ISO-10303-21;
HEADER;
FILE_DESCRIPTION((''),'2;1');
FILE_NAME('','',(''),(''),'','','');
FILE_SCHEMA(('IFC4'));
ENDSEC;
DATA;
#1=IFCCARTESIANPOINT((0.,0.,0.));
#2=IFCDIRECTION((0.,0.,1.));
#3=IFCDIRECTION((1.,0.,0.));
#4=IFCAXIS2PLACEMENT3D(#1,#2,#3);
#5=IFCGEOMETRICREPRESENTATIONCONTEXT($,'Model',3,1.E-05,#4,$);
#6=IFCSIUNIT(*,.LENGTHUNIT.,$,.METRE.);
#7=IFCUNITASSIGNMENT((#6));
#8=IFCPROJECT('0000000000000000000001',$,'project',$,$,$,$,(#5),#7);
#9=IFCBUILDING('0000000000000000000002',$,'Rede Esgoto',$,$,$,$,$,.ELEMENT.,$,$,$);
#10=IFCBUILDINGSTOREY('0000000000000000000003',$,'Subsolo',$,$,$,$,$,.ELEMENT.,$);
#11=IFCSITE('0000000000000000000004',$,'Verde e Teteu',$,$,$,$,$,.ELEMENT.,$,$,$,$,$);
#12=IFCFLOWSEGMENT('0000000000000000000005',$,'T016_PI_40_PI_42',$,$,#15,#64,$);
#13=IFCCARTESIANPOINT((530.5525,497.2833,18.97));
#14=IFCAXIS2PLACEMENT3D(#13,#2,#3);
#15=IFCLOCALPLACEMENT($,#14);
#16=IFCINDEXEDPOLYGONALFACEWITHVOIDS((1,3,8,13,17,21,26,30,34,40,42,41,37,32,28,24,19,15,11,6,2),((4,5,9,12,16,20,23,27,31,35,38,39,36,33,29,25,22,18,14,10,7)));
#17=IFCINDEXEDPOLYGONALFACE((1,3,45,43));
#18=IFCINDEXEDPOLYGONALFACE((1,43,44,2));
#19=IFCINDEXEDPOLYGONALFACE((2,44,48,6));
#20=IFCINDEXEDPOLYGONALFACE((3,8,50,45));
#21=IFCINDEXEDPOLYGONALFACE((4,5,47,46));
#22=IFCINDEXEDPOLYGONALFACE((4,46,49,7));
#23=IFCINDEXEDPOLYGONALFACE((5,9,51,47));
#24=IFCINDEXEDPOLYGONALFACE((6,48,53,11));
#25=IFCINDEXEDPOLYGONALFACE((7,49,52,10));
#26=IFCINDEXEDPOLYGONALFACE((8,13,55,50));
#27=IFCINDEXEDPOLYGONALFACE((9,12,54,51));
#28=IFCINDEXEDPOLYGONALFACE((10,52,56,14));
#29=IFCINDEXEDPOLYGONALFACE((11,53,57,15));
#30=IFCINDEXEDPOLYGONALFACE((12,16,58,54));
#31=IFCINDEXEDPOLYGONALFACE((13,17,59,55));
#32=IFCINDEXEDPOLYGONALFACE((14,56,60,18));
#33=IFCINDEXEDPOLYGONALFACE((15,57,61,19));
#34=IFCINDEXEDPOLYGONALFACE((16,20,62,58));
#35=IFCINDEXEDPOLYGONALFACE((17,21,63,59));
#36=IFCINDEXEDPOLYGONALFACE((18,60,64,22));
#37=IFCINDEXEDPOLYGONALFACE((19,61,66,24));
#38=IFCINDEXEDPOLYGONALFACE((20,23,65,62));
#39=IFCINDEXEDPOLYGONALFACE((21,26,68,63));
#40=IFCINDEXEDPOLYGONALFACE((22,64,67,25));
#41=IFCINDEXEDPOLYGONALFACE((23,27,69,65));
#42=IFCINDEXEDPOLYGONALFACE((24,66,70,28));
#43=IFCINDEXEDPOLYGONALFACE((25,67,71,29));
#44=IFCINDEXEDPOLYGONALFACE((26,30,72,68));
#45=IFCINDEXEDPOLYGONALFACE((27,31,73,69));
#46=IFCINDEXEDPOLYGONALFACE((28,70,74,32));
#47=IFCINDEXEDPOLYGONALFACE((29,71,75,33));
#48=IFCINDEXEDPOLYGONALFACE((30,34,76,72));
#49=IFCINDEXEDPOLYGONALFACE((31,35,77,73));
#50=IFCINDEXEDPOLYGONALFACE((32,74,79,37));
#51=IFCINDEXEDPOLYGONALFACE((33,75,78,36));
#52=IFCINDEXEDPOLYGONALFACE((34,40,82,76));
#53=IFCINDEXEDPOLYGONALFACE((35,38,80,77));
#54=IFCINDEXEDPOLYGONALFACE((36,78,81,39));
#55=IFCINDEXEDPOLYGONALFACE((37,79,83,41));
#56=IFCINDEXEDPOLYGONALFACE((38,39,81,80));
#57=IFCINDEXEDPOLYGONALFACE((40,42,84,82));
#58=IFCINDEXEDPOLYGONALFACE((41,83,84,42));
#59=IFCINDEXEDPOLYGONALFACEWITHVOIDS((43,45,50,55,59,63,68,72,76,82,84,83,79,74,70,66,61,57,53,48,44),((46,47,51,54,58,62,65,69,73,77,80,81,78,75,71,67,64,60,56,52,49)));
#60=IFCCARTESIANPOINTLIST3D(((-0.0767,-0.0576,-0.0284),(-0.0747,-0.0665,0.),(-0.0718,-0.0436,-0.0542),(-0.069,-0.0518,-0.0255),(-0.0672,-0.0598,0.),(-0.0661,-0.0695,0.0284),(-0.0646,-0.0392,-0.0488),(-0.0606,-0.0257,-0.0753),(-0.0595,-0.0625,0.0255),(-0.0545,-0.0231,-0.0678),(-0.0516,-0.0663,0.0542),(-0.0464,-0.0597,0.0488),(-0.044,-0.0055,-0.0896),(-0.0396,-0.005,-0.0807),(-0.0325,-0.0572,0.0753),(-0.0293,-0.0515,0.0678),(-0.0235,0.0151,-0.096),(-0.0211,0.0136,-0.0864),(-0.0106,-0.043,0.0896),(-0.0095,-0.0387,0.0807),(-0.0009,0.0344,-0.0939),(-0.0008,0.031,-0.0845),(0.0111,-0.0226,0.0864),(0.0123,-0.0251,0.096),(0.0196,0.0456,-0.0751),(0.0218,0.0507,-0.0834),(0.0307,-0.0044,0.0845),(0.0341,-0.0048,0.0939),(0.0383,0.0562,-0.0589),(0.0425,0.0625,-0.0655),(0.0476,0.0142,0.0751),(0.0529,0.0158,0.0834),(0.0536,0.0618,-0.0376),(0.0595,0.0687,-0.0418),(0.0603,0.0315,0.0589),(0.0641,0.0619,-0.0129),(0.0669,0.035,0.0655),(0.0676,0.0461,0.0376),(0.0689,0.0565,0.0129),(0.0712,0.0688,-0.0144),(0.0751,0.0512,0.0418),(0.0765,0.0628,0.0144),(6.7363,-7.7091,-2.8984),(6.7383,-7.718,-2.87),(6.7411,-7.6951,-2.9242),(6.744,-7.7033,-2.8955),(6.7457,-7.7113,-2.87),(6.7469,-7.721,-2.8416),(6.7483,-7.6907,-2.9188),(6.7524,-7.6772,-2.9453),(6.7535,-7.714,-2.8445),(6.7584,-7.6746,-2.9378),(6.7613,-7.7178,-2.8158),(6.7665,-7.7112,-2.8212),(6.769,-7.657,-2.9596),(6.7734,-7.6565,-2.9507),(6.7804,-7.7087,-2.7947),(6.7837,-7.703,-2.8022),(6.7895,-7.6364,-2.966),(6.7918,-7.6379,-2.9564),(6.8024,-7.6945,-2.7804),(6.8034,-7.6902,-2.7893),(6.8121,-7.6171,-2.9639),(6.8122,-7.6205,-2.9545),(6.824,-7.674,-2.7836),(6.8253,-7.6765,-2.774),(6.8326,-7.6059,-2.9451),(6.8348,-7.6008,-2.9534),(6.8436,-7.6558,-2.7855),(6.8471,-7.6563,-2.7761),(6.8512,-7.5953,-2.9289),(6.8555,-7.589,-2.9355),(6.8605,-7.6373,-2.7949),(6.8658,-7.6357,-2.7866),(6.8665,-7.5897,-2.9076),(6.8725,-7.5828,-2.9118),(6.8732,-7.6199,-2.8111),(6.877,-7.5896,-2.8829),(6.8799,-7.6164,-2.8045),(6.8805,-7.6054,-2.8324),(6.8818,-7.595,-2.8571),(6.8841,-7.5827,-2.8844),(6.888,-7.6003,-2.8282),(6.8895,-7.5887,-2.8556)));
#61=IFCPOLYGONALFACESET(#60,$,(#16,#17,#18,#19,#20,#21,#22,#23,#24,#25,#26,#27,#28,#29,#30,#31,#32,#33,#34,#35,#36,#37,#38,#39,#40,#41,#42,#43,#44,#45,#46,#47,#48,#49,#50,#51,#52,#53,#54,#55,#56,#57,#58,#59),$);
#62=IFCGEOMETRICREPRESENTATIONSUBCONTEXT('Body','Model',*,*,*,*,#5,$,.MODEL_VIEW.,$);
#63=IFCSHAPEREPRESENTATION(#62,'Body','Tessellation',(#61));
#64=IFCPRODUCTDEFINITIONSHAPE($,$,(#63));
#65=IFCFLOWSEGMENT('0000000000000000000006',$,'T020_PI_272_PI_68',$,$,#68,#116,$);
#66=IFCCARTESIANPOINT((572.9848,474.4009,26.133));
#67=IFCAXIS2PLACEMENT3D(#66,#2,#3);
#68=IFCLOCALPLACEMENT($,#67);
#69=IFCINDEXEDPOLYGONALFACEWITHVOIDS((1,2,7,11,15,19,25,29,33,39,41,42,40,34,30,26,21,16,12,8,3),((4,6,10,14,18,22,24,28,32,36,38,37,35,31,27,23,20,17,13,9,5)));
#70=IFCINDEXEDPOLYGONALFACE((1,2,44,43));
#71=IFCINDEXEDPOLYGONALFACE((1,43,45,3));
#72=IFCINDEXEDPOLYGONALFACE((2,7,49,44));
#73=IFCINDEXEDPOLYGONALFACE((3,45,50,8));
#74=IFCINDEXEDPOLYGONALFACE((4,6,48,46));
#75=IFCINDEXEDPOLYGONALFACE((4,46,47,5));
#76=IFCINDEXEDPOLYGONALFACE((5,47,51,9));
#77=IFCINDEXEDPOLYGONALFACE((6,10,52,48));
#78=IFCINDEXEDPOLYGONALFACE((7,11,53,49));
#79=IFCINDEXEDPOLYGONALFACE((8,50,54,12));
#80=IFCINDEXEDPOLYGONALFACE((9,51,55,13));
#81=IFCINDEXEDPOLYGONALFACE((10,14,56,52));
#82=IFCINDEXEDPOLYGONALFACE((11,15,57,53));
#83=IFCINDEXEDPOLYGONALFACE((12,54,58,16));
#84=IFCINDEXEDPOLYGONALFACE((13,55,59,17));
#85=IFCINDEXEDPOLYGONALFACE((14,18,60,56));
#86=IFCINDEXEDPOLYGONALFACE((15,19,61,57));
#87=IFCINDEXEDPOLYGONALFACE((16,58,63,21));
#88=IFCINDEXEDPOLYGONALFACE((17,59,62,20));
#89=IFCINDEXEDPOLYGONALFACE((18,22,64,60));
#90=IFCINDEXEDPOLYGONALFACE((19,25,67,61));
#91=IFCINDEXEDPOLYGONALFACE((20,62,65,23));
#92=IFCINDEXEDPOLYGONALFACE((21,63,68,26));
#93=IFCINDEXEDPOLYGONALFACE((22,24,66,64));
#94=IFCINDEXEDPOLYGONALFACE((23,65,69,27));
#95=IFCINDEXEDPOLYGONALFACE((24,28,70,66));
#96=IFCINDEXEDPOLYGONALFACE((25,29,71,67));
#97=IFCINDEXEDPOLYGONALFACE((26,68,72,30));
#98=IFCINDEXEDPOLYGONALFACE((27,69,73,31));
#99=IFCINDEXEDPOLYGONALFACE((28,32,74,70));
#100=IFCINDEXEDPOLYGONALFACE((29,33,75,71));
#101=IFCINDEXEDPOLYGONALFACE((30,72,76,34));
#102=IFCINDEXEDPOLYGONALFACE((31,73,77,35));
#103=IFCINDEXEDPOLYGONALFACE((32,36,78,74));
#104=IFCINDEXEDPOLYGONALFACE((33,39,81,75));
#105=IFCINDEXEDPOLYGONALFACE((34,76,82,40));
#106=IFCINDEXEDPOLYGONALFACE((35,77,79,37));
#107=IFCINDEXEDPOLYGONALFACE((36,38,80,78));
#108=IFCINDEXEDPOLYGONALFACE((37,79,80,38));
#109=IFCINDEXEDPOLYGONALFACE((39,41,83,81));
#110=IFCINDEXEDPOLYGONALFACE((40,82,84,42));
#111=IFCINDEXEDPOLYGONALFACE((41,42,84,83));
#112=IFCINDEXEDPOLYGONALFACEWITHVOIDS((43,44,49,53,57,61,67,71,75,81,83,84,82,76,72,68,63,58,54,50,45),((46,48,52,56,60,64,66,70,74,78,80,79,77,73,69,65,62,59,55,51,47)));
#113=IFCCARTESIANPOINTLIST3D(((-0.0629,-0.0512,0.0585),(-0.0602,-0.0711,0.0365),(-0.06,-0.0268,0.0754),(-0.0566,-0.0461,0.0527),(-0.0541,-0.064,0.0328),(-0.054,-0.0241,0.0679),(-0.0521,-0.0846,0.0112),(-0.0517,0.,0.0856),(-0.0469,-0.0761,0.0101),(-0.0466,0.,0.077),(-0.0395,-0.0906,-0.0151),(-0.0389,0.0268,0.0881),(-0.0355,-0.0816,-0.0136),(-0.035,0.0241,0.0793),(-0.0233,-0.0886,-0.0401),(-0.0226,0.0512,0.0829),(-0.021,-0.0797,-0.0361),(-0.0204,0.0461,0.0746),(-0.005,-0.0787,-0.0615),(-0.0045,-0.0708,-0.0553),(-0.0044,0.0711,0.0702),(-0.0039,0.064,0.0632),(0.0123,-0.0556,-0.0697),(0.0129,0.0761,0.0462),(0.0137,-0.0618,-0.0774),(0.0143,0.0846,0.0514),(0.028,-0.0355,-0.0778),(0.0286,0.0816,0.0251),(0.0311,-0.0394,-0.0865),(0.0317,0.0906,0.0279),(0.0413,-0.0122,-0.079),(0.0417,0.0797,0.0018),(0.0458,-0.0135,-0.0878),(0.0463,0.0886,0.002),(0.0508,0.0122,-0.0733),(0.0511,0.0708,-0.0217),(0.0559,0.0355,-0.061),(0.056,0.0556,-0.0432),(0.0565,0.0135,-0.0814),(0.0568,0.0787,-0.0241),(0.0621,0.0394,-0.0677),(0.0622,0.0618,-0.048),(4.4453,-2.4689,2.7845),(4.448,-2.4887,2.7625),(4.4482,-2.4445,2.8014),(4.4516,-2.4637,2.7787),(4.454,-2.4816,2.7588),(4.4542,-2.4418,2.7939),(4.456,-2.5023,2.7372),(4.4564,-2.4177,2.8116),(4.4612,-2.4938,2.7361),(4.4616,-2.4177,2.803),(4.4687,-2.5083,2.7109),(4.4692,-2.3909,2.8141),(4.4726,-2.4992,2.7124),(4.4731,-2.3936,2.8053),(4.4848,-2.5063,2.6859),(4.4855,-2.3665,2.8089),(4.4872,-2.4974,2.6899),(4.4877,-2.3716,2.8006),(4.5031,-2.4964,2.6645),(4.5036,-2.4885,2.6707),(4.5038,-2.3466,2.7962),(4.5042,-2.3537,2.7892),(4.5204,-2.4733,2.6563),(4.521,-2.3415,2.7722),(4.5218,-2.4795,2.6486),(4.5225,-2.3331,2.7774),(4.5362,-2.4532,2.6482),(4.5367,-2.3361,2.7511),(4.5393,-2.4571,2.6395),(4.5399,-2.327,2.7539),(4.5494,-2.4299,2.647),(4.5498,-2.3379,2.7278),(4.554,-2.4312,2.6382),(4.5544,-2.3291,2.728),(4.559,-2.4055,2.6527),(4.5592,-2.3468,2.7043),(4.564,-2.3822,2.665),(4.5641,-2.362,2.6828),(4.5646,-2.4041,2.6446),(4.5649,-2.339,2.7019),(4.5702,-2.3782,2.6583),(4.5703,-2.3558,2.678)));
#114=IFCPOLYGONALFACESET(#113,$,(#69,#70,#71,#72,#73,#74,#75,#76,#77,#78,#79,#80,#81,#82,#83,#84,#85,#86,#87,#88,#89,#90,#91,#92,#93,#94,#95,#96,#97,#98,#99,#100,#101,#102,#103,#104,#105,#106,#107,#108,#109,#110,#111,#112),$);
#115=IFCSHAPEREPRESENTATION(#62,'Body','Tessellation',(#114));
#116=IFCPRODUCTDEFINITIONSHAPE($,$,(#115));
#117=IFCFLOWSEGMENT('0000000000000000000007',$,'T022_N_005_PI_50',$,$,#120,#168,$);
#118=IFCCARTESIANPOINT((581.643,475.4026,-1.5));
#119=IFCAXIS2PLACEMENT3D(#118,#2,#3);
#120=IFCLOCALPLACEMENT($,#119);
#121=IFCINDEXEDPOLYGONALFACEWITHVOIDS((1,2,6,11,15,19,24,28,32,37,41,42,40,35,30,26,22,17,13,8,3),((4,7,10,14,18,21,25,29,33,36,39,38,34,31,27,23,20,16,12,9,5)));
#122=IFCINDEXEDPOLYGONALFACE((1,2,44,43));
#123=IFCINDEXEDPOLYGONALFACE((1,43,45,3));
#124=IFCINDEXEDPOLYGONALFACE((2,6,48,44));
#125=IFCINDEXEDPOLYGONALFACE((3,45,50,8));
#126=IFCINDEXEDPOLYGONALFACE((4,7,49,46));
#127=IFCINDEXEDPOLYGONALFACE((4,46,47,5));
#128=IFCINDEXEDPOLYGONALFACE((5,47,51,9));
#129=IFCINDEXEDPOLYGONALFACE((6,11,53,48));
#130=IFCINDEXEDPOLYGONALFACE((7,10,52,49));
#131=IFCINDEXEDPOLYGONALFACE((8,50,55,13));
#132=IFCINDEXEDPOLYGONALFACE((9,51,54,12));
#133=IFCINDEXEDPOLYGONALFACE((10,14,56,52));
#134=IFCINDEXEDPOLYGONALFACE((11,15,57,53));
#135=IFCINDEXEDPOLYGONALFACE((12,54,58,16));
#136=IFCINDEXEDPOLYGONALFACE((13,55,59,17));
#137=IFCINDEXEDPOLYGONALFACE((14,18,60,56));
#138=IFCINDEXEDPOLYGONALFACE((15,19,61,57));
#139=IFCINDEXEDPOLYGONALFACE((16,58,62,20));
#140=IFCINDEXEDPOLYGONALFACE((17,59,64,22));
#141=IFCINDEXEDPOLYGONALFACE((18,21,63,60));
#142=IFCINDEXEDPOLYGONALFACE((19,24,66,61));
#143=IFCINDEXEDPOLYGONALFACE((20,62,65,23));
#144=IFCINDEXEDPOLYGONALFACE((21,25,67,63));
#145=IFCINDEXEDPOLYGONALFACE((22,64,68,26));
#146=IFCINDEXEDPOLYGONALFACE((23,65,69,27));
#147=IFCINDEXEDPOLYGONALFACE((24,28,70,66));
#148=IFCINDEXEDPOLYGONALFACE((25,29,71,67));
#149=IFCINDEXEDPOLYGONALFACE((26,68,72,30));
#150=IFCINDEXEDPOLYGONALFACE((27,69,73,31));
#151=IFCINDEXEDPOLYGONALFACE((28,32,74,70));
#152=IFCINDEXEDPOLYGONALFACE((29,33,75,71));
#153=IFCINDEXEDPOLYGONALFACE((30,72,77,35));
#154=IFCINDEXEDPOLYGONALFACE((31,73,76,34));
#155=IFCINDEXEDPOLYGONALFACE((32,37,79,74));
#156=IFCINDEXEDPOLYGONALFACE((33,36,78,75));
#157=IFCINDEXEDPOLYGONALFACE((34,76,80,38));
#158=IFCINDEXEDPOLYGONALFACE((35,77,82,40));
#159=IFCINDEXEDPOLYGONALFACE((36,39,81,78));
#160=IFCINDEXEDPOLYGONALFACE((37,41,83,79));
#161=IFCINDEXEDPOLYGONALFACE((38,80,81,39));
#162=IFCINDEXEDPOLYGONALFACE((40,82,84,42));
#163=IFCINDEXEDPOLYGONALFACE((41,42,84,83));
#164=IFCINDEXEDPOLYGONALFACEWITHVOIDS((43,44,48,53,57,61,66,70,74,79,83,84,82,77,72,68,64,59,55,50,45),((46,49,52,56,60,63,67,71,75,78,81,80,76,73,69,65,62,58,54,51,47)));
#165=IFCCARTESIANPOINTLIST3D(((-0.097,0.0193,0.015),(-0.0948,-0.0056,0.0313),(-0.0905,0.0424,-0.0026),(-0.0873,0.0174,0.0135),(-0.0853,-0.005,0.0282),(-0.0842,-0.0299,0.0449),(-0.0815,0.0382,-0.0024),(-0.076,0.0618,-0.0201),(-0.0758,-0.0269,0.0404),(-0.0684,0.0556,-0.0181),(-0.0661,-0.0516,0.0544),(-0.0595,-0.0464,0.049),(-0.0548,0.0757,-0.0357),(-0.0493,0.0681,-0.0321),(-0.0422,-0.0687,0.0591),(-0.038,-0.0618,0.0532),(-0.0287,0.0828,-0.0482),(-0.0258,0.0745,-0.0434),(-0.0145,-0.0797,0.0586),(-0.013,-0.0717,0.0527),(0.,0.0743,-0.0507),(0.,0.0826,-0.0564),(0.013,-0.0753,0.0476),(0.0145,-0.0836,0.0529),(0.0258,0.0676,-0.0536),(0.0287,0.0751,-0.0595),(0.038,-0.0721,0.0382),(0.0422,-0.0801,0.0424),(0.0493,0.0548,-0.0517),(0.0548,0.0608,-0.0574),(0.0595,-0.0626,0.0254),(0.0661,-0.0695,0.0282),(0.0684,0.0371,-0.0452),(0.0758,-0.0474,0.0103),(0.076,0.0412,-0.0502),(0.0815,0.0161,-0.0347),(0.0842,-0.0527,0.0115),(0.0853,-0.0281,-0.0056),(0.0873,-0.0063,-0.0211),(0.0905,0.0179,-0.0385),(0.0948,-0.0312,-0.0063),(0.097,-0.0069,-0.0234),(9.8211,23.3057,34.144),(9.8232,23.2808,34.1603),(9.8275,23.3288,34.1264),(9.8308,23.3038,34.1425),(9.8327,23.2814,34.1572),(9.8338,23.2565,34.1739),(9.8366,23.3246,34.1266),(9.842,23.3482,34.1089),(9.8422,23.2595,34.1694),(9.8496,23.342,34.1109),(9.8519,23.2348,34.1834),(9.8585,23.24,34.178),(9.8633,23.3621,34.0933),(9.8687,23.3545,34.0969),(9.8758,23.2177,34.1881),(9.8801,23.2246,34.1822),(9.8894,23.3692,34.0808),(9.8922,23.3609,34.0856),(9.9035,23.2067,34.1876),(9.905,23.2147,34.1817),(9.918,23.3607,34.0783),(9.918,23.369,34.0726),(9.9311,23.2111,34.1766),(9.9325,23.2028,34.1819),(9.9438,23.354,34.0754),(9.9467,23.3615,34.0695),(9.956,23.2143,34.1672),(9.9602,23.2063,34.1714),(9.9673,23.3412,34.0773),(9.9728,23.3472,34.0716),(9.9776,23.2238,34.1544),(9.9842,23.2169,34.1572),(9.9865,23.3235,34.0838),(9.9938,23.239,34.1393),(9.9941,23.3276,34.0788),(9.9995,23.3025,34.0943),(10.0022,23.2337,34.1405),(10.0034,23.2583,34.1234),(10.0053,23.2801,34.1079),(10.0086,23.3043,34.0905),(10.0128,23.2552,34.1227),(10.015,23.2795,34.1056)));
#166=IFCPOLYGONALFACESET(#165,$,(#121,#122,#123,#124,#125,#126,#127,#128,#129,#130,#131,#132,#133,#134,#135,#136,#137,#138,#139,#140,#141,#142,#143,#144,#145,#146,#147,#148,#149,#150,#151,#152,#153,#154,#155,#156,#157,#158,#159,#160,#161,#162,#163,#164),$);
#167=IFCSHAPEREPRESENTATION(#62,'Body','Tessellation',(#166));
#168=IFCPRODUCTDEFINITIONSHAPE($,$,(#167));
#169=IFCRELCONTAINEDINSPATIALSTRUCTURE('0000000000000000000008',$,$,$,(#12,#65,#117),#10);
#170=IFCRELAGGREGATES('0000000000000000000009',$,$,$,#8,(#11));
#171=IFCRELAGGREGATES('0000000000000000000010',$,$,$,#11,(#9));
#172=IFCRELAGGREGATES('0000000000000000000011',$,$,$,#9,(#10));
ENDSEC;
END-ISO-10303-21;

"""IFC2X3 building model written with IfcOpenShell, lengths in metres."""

from ifc_helpers import new_model, entity, si_unit, frame, origin_with_axes, place, context, subcontext, project, spatial, element, save


model = new_model("IFC2X3")

# Units and contexts
model_context = context("Model", 3, precision=1e-05, world=origin_with_axes())
body_context = subcontext(model_context, "Body", "Model", "MODEL_VIEW")
ifc_project = project(units=[si_unit("LENGTHUNIT", "METRE")], contexts=[model_context])

# Site, building, storey
site = spatial("IfcSite", under=ifc_project, Name="Verde e Teteu", CompositionType="ELEMENT")
building = spatial("IfcBuilding", under=site, Name="Rede Esgoto", CompositionType="ELEMENT")
storey = spatial("IfcBuildingStorey", under=building, Name="Subsolo", CompositionType="ELEMENT")

# Flow segments
flow_segment_1_placement = place(None, frame((530.5525, 497.2833, 18.97), z_axis=(0.0, 0.0, 1.0), x_axis=(1.0, 0.0, 0.0)))
element("IfcFlowSegment", 1, at=flow_segment_1_placement, inside=storey, Name="T016_PI_40_PI_42", context=body_context, shape_type="SweptSolid", body=[
    entity("IfcSweptDiskSolid", entity("IfcPolyline", [entity("IfcCartesianPoint", [0.0, 0.0, 0.0]), entity("IfcCartesianPoint", [6.8129, -7.6515, -2.87])]), 0.1, 0.09),
])
flow_segment_2_placement = place(None, frame((572.9848, 474.4009, 26.133), z_axis=(0.0, 0.0, 1.0), x_axis=(1.0, 0.0, 0.0)))
element("IfcFlowSegment", 2, at=flow_segment_2_placement, inside=storey, Name="T020_PI_272_PI_68", context=body_context, shape_type="SweptSolid", body=[
    entity("IfcSweptDiskSolid", entity("IfcPolyline", [entity("IfcCartesianPoint", [0.0, 0.0, 0.0]), entity("IfcCartesianPoint", [4.5081, -2.4177, 2.726])]), 0.1, 0.09),
])
flow_segment_3_placement = place(None, frame((581.643, 475.4026, -1.5), z_axis=(0.0, 0.0, 1.0), x_axis=(1.0, 0.0, 0.0)))
element("IfcFlowSegment", 3, at=flow_segment_3_placement, inside=storey, Name="T022_N_005_PI_50", context=body_context, shape_type="SweptSolid", body=[
    entity("IfcSweptDiskSolid", entity("IfcPolyline", [entity("IfcCartesianPoint", [0.0, 0.0, 0.0]), entity("IfcCartesianPoint", [9.918, 23.2864, 34.129])]), 0.1, 0.09),
])

save(model, "model.ifc")
